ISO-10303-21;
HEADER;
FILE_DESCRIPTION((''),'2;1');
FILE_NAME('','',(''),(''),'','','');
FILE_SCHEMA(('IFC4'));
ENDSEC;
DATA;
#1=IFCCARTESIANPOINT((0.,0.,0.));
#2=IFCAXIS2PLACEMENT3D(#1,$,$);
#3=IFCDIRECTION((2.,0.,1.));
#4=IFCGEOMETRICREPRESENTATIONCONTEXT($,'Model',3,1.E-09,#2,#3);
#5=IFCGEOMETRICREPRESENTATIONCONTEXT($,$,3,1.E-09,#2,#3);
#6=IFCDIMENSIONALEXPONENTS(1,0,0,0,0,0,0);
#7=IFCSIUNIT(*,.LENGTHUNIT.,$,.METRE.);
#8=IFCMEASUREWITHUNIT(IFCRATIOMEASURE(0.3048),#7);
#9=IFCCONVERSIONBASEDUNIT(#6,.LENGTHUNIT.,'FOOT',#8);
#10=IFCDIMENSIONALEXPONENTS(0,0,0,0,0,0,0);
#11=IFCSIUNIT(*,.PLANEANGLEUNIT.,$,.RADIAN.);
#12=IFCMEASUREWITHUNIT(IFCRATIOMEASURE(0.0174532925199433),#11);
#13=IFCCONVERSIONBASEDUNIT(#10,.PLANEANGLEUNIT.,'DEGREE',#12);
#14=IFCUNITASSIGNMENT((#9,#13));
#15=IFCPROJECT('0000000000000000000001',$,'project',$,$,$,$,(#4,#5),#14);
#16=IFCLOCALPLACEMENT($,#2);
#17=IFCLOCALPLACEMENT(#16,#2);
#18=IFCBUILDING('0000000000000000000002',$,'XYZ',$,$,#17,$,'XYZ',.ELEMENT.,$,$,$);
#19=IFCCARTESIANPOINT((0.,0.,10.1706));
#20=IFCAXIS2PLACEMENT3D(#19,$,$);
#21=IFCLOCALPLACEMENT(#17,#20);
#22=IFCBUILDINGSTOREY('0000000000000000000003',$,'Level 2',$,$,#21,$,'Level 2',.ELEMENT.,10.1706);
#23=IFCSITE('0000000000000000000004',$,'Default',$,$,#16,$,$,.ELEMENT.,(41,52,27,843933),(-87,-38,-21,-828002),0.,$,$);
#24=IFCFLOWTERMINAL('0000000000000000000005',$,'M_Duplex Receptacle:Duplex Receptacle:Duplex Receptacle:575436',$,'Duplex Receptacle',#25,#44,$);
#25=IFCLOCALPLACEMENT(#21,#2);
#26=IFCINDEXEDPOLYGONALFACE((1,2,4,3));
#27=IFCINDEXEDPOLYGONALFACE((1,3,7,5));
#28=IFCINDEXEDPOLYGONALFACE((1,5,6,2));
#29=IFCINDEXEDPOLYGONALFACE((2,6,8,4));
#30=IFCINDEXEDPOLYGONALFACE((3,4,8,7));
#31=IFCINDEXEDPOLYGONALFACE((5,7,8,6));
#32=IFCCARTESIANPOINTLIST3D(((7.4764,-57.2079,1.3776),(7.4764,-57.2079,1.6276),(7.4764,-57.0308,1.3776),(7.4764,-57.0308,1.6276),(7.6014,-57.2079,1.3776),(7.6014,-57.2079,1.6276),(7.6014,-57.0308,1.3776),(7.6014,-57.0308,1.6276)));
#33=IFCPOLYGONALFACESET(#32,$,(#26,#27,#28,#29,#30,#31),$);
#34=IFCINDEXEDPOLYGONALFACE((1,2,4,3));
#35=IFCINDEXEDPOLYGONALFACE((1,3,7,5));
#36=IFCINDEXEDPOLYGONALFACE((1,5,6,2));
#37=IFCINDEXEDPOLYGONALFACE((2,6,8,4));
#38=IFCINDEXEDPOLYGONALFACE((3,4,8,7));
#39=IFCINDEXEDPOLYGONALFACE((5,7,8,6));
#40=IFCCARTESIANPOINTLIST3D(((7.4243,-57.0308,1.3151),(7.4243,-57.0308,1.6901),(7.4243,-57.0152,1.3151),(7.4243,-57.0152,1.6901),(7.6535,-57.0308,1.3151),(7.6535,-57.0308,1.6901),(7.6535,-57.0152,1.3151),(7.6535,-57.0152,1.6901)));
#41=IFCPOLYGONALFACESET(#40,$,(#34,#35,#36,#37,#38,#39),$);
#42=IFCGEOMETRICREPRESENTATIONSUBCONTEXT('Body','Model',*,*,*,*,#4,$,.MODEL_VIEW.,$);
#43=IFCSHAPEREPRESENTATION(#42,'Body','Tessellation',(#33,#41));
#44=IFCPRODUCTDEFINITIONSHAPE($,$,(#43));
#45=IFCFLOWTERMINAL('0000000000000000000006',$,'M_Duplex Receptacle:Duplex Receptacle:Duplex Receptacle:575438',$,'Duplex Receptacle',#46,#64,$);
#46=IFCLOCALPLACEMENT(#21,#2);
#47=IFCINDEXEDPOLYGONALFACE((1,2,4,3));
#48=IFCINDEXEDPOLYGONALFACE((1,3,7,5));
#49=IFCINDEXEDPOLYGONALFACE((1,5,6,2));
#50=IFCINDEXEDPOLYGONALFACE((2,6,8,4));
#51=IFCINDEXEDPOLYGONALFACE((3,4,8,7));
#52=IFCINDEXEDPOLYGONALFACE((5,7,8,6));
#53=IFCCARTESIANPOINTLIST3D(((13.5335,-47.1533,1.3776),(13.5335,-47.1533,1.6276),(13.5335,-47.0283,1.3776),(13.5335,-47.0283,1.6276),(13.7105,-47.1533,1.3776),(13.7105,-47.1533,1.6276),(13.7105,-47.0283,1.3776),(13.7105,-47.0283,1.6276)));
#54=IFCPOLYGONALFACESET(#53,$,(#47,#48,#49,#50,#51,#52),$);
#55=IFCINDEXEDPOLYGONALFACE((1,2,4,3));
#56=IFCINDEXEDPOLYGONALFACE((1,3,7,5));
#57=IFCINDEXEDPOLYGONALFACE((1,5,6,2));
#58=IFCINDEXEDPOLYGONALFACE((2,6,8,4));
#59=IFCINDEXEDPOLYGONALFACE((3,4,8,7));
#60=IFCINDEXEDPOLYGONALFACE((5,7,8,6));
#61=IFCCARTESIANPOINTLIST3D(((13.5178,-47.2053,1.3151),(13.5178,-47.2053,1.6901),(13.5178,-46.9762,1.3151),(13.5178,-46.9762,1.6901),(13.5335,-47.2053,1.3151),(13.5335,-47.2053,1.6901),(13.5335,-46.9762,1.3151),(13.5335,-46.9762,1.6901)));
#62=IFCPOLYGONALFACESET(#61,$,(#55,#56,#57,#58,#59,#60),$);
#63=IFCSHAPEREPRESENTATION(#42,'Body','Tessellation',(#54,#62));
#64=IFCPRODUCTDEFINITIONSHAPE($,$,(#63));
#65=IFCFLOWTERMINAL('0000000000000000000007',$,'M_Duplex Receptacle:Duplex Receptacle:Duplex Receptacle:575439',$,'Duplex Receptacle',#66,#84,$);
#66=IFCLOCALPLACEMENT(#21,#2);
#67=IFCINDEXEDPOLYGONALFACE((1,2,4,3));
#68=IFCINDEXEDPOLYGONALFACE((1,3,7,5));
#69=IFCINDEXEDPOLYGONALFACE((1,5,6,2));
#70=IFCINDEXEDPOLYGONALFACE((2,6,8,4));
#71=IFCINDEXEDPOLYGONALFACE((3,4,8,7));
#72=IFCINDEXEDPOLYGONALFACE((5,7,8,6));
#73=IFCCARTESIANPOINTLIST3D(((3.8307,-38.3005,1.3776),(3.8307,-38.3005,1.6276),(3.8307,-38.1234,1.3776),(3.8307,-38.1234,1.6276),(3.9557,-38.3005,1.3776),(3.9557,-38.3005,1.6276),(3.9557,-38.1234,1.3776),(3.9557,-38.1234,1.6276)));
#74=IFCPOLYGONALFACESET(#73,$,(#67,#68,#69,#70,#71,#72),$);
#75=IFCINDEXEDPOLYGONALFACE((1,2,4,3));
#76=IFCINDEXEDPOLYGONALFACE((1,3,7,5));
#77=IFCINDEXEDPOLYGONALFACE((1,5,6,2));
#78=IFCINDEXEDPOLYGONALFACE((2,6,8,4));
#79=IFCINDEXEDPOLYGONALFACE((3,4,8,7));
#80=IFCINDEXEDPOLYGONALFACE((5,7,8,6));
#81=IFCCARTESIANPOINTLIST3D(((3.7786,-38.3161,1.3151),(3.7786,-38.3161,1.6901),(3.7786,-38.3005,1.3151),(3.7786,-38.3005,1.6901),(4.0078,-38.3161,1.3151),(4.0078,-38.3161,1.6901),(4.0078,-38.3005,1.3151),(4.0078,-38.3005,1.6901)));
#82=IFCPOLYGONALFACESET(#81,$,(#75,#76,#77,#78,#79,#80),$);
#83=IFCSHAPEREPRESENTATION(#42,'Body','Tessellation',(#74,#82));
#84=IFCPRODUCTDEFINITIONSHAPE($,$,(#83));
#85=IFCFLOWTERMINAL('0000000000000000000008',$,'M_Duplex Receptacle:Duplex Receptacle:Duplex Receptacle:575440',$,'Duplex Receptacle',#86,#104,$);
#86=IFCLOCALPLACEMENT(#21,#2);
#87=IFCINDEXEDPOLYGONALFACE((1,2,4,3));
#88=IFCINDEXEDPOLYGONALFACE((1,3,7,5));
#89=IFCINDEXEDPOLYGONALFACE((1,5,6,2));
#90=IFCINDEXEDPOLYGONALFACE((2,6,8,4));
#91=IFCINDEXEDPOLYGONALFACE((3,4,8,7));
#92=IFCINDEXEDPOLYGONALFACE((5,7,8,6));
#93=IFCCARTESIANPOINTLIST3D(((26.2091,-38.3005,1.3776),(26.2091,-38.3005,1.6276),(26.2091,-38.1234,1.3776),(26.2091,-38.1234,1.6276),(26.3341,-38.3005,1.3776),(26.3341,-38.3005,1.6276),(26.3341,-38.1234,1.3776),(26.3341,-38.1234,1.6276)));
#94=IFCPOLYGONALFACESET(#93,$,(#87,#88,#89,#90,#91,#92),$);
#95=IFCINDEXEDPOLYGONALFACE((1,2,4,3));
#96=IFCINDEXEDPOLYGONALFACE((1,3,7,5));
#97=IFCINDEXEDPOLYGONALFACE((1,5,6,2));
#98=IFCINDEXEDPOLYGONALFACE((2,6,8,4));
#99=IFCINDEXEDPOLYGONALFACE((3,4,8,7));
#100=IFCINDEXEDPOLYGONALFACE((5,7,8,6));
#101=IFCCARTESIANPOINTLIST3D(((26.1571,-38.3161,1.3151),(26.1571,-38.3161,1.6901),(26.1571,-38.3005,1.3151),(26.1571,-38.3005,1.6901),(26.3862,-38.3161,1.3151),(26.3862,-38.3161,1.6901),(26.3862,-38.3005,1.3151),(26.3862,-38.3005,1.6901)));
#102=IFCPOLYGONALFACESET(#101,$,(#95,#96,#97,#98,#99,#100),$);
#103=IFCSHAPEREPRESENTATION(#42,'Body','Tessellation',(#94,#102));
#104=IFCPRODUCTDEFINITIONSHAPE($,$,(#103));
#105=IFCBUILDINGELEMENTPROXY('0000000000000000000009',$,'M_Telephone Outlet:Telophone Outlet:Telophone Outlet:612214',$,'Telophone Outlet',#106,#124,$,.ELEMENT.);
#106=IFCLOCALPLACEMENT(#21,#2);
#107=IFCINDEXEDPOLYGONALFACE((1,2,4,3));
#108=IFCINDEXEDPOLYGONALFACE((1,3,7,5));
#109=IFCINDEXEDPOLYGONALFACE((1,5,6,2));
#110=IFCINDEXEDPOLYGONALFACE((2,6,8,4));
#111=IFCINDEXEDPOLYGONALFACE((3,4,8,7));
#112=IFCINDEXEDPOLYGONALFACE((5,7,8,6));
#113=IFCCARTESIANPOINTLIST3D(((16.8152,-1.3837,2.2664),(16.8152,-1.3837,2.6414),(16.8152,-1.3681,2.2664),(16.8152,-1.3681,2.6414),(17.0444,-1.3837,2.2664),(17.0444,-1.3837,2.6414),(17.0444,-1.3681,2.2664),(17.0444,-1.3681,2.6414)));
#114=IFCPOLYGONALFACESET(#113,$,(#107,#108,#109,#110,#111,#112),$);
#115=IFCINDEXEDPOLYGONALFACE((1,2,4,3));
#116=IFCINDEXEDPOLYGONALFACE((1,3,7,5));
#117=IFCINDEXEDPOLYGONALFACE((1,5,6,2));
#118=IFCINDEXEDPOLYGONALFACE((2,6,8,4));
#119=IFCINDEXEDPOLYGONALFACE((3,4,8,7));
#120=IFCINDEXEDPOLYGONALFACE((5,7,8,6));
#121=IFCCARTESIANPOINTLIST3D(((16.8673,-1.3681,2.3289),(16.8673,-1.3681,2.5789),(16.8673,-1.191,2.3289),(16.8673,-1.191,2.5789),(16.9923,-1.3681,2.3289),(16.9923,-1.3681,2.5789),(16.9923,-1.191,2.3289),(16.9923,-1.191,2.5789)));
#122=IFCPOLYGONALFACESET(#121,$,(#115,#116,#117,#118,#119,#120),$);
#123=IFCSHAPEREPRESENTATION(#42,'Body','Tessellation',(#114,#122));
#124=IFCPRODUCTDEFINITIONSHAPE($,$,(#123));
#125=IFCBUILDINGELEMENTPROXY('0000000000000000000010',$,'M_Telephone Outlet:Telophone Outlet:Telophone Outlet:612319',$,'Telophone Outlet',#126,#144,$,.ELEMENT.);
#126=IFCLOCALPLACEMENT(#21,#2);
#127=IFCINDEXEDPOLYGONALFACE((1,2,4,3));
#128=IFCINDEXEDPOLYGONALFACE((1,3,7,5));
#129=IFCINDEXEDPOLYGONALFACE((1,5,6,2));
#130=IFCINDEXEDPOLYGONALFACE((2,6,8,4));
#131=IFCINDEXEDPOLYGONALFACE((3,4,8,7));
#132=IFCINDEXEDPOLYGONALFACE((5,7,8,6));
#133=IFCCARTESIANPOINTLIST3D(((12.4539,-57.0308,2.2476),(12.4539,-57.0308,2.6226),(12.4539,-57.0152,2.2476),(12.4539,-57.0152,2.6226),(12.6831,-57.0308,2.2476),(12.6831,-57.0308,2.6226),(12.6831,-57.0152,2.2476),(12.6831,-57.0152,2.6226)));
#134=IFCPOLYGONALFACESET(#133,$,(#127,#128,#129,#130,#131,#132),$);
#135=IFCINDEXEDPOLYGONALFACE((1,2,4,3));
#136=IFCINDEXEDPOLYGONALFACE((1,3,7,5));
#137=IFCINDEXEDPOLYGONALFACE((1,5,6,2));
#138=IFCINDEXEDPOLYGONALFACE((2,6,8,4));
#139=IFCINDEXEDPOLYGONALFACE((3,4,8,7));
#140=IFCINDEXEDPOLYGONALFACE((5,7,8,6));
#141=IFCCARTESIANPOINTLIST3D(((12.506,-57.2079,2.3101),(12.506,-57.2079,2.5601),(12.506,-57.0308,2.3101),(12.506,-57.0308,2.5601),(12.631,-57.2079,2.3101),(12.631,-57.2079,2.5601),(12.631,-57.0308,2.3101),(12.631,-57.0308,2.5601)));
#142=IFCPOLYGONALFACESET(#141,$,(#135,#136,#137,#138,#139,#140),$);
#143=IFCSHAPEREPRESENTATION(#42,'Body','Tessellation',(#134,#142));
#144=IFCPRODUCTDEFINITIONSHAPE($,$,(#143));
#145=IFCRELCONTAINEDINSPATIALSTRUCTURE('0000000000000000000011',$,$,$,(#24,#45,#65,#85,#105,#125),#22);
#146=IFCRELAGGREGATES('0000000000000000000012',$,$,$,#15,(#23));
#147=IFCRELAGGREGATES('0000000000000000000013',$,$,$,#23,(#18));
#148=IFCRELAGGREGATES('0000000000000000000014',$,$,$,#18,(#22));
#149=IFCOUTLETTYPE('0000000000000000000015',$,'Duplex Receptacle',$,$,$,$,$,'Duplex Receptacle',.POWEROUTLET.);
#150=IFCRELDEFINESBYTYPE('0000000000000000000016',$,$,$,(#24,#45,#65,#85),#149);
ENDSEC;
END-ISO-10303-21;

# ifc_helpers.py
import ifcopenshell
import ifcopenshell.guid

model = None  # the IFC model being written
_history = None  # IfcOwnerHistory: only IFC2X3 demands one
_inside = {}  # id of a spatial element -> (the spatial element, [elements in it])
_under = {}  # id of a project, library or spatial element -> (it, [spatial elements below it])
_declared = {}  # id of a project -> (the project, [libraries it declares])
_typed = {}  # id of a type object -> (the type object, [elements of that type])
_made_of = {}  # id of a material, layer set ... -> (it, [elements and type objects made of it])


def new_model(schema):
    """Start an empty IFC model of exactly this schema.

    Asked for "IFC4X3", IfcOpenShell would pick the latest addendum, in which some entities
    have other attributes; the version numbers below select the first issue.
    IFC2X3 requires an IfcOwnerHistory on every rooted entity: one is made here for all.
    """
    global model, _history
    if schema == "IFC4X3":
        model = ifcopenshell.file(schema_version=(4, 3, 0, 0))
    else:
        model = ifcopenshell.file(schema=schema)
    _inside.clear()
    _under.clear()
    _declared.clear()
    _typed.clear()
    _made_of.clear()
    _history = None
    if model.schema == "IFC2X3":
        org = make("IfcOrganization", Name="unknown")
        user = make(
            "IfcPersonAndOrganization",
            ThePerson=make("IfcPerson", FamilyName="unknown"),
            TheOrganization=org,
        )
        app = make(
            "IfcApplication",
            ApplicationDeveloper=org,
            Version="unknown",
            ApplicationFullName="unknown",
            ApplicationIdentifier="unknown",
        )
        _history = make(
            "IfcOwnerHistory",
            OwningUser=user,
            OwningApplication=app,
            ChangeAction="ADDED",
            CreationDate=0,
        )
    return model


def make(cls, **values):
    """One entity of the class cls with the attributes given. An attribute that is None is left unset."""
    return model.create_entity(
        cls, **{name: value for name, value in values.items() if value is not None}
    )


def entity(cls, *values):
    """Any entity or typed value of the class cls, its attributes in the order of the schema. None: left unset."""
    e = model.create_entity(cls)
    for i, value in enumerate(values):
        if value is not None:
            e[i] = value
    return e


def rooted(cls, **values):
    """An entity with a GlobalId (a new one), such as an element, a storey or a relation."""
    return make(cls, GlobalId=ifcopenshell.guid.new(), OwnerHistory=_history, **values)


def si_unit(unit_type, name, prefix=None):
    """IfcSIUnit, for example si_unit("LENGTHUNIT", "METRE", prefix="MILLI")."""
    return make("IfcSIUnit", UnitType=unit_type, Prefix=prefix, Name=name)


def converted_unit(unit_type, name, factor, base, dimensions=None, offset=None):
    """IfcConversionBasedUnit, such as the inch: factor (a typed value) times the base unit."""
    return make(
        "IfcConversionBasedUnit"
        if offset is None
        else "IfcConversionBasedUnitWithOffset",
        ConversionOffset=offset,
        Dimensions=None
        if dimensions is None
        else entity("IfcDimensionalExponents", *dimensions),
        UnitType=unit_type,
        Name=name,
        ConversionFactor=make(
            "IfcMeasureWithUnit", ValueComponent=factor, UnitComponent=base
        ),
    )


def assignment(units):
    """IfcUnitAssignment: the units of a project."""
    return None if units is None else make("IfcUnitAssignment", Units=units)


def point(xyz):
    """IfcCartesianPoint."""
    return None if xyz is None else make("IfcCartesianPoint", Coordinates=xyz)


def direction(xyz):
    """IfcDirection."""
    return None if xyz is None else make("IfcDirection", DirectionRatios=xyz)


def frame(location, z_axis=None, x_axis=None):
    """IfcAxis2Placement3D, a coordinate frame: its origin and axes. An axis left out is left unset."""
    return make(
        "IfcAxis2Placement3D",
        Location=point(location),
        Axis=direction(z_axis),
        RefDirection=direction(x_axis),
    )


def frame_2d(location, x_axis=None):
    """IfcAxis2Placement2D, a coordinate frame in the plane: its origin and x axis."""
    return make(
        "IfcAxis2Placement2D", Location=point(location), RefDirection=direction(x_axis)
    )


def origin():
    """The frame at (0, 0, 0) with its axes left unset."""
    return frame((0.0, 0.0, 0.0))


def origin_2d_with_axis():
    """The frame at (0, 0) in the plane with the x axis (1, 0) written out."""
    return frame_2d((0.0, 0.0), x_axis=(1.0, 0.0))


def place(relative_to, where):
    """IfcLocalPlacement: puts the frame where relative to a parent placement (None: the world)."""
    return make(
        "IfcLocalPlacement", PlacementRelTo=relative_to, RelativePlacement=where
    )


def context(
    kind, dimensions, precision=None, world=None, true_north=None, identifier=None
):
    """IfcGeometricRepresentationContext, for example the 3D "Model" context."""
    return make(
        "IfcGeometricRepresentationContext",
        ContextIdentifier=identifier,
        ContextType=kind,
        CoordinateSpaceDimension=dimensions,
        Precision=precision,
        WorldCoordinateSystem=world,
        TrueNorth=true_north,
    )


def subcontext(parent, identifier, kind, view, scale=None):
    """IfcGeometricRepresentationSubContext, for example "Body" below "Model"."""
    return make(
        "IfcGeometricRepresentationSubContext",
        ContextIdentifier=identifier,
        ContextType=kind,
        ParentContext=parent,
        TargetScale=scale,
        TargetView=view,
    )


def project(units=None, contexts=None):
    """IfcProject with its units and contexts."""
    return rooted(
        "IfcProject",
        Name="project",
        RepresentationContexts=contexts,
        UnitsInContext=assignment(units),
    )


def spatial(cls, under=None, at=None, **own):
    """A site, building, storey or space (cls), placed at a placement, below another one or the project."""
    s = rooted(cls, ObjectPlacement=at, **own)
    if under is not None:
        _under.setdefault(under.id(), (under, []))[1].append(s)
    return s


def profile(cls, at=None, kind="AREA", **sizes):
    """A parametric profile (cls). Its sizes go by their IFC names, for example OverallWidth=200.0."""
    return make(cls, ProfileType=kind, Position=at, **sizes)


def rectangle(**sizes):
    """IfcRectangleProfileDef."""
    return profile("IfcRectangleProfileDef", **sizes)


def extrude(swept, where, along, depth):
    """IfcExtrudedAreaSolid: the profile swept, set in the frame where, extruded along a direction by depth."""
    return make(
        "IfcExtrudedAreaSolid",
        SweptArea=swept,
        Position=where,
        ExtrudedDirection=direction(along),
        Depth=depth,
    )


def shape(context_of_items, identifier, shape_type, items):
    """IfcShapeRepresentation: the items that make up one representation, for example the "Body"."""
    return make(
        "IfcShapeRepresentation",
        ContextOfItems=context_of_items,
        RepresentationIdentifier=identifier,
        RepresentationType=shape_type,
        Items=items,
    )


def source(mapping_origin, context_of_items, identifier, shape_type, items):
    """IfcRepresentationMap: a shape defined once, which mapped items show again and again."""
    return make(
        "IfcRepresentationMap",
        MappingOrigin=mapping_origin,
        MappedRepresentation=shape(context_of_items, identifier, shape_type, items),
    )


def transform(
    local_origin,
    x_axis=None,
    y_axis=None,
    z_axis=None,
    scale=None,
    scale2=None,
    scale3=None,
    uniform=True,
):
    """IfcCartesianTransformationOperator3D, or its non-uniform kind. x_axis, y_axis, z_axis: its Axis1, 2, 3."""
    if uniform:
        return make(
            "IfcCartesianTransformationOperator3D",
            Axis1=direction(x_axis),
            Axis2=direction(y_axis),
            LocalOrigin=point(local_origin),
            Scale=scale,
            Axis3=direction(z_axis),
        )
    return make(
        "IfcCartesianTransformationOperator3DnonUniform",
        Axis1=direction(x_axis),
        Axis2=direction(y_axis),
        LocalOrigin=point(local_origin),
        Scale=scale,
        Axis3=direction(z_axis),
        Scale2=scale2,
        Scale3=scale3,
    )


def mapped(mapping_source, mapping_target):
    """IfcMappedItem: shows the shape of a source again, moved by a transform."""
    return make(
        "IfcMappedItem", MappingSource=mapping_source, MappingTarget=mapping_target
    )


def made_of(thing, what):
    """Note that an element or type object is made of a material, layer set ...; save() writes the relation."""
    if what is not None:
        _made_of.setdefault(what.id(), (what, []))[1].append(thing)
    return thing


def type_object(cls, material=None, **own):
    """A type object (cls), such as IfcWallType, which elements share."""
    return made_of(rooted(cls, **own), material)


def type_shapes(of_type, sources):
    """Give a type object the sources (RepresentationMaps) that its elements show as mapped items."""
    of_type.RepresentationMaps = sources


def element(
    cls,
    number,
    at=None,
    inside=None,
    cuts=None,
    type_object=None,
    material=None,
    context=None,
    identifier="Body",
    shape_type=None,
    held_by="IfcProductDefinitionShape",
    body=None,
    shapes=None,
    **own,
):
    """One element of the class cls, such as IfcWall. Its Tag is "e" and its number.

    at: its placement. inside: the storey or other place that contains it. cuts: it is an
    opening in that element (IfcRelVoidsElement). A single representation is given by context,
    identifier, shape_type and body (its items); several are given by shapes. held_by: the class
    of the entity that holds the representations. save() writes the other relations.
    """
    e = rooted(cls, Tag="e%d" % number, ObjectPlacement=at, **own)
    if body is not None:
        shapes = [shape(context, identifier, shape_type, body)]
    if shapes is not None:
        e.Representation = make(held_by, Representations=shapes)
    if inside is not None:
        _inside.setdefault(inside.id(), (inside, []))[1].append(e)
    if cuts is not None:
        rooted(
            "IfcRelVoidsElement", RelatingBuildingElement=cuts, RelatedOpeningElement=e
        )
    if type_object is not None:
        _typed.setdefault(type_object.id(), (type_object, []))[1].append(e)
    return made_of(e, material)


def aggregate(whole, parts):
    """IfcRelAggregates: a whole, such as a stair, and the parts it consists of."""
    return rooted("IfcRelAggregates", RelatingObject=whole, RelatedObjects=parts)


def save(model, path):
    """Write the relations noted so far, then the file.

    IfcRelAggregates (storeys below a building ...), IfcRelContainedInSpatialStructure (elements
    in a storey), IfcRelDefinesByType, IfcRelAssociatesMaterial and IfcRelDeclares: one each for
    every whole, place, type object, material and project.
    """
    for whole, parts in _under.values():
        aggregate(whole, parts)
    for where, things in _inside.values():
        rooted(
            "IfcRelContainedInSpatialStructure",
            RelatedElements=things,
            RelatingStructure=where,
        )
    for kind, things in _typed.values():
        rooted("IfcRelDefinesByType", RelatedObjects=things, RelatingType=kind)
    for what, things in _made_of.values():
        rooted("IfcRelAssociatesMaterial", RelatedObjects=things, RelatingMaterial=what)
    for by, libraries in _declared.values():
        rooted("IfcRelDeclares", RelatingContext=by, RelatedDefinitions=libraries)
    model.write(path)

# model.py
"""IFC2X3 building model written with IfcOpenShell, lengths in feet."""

from ifc_helpers import new_model, entity, si_unit, converted_unit, direction, frame, frame_2d, origin, origin_2d_with_axis, place, context, subcontext, project, spatial, rectangle, extrude, source, transform, mapped, type_object, type_shapes, element, save


model = new_model("IFC2X3")

# Units and contexts
model_context = context("Model", 3, precision=1e-09, world=origin(), true_north=direction((2.0, 0.0, 1.0)))
context_of_model = context(None, 3, precision=1e-09, world=origin(), true_north=direction((2.0, 0.0, 1.0)))
body_context = subcontext(model_context, "Body", "Model", "MODEL_VIEW")
ifc_project = project(units=[converted_unit("LENGTHUNIT", "FOOT", entity("IfcRatioMeasure", 0.3048), si_unit("LENGTHUNIT", "METRE"), dimensions=[1, 0, 0, 0, 0, 0, 0]), converted_unit("PLANEANGLEUNIT", "DEGREE", entity("IfcRatioMeasure", 0.0174532925199433), si_unit("PLANEANGLEUNIT", "RADIAN"), dimensions=[0, 0, 0, 0, 0, 0, 0])], contexts=[model_context, context_of_model])

# Site, building, storey
site_placement = place(None, origin())
site = spatial("IfcSite", under=ifc_project, at=site_placement, Name="Default", CompositionType="ELEMENT", RefLatitude=(41, 52, 27, 843933), RefLongitude=(-87, -38, -21, -828002), RefElevation=0.0)
building_placement = place(site_placement, origin())
building = spatial("IfcBuilding", under=site, at=building_placement, Name="XYZ", LongName="XYZ", CompositionType="ELEMENT")
storey_placement = place(building_placement, frame((0.0, 0.0, 10.1706)))
storey = spatial("IfcBuildingStorey", under=building, at=storey_placement, Name="Level 2", LongName="Level 2", CompositionType="ELEMENT", Elevation=10.1706)

# Flow terminals
outlet_type = type_object("IfcOutletType", Name="Duplex Receptacle", ElementType="Duplex Receptacle", PredefinedType="POWEROUTLET")
shared_shape_1 = source(origin(), body_context, "Body", "SweptSolid", [
    extrude(rectangle(XDim=0.125, YDim=0.25, at=origin_2d_with_axis()), frame((0.0, 0.0, -0.1771), z_axis=(0.0, 0.0, 1.0), x_axis=(-1.0, 0.0, 0.0)), (0.0, 0.0, 1.0), 0.1771),
    extrude(rectangle(XDim=0.2292, YDim=0.375, at=frame_2d((0.0, 0.0), x_axis=(1.0, 0.0))), frame((0.0, 0.0, 0.0), z_axis=(0.0, 0.0, 1.0), x_axis=(-1.0, 0.0, 0.0)), (0.0, 0.0, 1.0), 0.0156),
])
type_shapes(outlet_type, [shared_shape_1])
for number, where, z_axis, x_axis, name in (
    (1, (7.5389, -57.0308, 1.5026), (0.0, 1.0, 0.0), (-1.0, 0.0, 0.0), "M_Duplex Receptacle:Duplex Receptacle:Duplex Receptacle:575436"),
    (2, (13.5335, -47.0908, 1.5026), (-1.0, 0.0, 0.0), (0.0, -1.0, 0.0), "M_Duplex Receptacle:Duplex Receptacle:Duplex Receptacle:575438"),
    (3, (3.8932, -38.3005, 1.5026), (0.0, -1.0, 0.0), (1.0, 0.0, 0.0), "M_Duplex Receptacle:Duplex Receptacle:Duplex Receptacle:575439"),
    (4, (26.2716, -38.3005, 1.5026), (0.0, -1.0, 0.0), (1.0, 0.0, 0.0), "M_Duplex Receptacle:Duplex Receptacle:Duplex Receptacle:575440"),
):
    element("IfcFlowTerminal", number, at=place(storey_placement, frame(where, z_axis=z_axis, x_axis=x_axis)), inside=storey, type_object=outlet_type, Name=name, ObjectType="Duplex Receptacle", context=body_context, shape_type="MappedRepresentation", body=[
        mapped(shared_shape_1, transform((0.0, 0.0, 0.0), scale=1.0)),
    ])

# Building element proxies
shared_shape_2 = source(origin(), body_context, "Body", "SweptSolid", [
    extrude(rectangle(XDim=0.2292, YDim=0.375, at=frame_2d((0.0, 0.0), x_axis=(1.0, 0.0))), frame((0.0, 0.0, 0.0), z_axis=(0.0, 0.0, 1.0), x_axis=(-1.0, 0.0, 0.0)), (0.0, 0.0, 1.0), 0.0156),
    extrude(rectangle(XDim=0.125, YDim=0.25, at=origin_2d_with_axis()), frame((0.0, 0.0, -0.1771), z_axis=(0.0, 0.0, 1.0), x_axis=(-1.0, 0.0, 0.0)), (0.0, 0.0, 1.0), 0.1771),
])
for number, where, z_axis, x_axis, name in (
    (5, (16.9298, -1.3681, 2.4539), (0.0, -1.0, 0.0), (1.0, 0.0, 0.0), "M_Telephone Outlet:Telophone Outlet:Telophone Outlet:612214"),
    (6, (12.5685, -57.0308, 2.4351), (0.0, 1.0, 0.0), (-1.0, 0.0, 0.0), "M_Telephone Outlet:Telophone Outlet:Telophone Outlet:612319"),
):
    element("IfcBuildingElementProxy", number, at=place(storey_placement, frame(where, z_axis=z_axis, x_axis=x_axis)), inside=storey, Name=name, ObjectType="Telophone Outlet", CompositionType="ELEMENT", context=body_context, shape_type="MappedRepresentation", body=[
        mapped(shared_shape_2, transform((0.0, 0.0, 0.0), scale=1.0)),
    ])

save(model, "model.ifc")
